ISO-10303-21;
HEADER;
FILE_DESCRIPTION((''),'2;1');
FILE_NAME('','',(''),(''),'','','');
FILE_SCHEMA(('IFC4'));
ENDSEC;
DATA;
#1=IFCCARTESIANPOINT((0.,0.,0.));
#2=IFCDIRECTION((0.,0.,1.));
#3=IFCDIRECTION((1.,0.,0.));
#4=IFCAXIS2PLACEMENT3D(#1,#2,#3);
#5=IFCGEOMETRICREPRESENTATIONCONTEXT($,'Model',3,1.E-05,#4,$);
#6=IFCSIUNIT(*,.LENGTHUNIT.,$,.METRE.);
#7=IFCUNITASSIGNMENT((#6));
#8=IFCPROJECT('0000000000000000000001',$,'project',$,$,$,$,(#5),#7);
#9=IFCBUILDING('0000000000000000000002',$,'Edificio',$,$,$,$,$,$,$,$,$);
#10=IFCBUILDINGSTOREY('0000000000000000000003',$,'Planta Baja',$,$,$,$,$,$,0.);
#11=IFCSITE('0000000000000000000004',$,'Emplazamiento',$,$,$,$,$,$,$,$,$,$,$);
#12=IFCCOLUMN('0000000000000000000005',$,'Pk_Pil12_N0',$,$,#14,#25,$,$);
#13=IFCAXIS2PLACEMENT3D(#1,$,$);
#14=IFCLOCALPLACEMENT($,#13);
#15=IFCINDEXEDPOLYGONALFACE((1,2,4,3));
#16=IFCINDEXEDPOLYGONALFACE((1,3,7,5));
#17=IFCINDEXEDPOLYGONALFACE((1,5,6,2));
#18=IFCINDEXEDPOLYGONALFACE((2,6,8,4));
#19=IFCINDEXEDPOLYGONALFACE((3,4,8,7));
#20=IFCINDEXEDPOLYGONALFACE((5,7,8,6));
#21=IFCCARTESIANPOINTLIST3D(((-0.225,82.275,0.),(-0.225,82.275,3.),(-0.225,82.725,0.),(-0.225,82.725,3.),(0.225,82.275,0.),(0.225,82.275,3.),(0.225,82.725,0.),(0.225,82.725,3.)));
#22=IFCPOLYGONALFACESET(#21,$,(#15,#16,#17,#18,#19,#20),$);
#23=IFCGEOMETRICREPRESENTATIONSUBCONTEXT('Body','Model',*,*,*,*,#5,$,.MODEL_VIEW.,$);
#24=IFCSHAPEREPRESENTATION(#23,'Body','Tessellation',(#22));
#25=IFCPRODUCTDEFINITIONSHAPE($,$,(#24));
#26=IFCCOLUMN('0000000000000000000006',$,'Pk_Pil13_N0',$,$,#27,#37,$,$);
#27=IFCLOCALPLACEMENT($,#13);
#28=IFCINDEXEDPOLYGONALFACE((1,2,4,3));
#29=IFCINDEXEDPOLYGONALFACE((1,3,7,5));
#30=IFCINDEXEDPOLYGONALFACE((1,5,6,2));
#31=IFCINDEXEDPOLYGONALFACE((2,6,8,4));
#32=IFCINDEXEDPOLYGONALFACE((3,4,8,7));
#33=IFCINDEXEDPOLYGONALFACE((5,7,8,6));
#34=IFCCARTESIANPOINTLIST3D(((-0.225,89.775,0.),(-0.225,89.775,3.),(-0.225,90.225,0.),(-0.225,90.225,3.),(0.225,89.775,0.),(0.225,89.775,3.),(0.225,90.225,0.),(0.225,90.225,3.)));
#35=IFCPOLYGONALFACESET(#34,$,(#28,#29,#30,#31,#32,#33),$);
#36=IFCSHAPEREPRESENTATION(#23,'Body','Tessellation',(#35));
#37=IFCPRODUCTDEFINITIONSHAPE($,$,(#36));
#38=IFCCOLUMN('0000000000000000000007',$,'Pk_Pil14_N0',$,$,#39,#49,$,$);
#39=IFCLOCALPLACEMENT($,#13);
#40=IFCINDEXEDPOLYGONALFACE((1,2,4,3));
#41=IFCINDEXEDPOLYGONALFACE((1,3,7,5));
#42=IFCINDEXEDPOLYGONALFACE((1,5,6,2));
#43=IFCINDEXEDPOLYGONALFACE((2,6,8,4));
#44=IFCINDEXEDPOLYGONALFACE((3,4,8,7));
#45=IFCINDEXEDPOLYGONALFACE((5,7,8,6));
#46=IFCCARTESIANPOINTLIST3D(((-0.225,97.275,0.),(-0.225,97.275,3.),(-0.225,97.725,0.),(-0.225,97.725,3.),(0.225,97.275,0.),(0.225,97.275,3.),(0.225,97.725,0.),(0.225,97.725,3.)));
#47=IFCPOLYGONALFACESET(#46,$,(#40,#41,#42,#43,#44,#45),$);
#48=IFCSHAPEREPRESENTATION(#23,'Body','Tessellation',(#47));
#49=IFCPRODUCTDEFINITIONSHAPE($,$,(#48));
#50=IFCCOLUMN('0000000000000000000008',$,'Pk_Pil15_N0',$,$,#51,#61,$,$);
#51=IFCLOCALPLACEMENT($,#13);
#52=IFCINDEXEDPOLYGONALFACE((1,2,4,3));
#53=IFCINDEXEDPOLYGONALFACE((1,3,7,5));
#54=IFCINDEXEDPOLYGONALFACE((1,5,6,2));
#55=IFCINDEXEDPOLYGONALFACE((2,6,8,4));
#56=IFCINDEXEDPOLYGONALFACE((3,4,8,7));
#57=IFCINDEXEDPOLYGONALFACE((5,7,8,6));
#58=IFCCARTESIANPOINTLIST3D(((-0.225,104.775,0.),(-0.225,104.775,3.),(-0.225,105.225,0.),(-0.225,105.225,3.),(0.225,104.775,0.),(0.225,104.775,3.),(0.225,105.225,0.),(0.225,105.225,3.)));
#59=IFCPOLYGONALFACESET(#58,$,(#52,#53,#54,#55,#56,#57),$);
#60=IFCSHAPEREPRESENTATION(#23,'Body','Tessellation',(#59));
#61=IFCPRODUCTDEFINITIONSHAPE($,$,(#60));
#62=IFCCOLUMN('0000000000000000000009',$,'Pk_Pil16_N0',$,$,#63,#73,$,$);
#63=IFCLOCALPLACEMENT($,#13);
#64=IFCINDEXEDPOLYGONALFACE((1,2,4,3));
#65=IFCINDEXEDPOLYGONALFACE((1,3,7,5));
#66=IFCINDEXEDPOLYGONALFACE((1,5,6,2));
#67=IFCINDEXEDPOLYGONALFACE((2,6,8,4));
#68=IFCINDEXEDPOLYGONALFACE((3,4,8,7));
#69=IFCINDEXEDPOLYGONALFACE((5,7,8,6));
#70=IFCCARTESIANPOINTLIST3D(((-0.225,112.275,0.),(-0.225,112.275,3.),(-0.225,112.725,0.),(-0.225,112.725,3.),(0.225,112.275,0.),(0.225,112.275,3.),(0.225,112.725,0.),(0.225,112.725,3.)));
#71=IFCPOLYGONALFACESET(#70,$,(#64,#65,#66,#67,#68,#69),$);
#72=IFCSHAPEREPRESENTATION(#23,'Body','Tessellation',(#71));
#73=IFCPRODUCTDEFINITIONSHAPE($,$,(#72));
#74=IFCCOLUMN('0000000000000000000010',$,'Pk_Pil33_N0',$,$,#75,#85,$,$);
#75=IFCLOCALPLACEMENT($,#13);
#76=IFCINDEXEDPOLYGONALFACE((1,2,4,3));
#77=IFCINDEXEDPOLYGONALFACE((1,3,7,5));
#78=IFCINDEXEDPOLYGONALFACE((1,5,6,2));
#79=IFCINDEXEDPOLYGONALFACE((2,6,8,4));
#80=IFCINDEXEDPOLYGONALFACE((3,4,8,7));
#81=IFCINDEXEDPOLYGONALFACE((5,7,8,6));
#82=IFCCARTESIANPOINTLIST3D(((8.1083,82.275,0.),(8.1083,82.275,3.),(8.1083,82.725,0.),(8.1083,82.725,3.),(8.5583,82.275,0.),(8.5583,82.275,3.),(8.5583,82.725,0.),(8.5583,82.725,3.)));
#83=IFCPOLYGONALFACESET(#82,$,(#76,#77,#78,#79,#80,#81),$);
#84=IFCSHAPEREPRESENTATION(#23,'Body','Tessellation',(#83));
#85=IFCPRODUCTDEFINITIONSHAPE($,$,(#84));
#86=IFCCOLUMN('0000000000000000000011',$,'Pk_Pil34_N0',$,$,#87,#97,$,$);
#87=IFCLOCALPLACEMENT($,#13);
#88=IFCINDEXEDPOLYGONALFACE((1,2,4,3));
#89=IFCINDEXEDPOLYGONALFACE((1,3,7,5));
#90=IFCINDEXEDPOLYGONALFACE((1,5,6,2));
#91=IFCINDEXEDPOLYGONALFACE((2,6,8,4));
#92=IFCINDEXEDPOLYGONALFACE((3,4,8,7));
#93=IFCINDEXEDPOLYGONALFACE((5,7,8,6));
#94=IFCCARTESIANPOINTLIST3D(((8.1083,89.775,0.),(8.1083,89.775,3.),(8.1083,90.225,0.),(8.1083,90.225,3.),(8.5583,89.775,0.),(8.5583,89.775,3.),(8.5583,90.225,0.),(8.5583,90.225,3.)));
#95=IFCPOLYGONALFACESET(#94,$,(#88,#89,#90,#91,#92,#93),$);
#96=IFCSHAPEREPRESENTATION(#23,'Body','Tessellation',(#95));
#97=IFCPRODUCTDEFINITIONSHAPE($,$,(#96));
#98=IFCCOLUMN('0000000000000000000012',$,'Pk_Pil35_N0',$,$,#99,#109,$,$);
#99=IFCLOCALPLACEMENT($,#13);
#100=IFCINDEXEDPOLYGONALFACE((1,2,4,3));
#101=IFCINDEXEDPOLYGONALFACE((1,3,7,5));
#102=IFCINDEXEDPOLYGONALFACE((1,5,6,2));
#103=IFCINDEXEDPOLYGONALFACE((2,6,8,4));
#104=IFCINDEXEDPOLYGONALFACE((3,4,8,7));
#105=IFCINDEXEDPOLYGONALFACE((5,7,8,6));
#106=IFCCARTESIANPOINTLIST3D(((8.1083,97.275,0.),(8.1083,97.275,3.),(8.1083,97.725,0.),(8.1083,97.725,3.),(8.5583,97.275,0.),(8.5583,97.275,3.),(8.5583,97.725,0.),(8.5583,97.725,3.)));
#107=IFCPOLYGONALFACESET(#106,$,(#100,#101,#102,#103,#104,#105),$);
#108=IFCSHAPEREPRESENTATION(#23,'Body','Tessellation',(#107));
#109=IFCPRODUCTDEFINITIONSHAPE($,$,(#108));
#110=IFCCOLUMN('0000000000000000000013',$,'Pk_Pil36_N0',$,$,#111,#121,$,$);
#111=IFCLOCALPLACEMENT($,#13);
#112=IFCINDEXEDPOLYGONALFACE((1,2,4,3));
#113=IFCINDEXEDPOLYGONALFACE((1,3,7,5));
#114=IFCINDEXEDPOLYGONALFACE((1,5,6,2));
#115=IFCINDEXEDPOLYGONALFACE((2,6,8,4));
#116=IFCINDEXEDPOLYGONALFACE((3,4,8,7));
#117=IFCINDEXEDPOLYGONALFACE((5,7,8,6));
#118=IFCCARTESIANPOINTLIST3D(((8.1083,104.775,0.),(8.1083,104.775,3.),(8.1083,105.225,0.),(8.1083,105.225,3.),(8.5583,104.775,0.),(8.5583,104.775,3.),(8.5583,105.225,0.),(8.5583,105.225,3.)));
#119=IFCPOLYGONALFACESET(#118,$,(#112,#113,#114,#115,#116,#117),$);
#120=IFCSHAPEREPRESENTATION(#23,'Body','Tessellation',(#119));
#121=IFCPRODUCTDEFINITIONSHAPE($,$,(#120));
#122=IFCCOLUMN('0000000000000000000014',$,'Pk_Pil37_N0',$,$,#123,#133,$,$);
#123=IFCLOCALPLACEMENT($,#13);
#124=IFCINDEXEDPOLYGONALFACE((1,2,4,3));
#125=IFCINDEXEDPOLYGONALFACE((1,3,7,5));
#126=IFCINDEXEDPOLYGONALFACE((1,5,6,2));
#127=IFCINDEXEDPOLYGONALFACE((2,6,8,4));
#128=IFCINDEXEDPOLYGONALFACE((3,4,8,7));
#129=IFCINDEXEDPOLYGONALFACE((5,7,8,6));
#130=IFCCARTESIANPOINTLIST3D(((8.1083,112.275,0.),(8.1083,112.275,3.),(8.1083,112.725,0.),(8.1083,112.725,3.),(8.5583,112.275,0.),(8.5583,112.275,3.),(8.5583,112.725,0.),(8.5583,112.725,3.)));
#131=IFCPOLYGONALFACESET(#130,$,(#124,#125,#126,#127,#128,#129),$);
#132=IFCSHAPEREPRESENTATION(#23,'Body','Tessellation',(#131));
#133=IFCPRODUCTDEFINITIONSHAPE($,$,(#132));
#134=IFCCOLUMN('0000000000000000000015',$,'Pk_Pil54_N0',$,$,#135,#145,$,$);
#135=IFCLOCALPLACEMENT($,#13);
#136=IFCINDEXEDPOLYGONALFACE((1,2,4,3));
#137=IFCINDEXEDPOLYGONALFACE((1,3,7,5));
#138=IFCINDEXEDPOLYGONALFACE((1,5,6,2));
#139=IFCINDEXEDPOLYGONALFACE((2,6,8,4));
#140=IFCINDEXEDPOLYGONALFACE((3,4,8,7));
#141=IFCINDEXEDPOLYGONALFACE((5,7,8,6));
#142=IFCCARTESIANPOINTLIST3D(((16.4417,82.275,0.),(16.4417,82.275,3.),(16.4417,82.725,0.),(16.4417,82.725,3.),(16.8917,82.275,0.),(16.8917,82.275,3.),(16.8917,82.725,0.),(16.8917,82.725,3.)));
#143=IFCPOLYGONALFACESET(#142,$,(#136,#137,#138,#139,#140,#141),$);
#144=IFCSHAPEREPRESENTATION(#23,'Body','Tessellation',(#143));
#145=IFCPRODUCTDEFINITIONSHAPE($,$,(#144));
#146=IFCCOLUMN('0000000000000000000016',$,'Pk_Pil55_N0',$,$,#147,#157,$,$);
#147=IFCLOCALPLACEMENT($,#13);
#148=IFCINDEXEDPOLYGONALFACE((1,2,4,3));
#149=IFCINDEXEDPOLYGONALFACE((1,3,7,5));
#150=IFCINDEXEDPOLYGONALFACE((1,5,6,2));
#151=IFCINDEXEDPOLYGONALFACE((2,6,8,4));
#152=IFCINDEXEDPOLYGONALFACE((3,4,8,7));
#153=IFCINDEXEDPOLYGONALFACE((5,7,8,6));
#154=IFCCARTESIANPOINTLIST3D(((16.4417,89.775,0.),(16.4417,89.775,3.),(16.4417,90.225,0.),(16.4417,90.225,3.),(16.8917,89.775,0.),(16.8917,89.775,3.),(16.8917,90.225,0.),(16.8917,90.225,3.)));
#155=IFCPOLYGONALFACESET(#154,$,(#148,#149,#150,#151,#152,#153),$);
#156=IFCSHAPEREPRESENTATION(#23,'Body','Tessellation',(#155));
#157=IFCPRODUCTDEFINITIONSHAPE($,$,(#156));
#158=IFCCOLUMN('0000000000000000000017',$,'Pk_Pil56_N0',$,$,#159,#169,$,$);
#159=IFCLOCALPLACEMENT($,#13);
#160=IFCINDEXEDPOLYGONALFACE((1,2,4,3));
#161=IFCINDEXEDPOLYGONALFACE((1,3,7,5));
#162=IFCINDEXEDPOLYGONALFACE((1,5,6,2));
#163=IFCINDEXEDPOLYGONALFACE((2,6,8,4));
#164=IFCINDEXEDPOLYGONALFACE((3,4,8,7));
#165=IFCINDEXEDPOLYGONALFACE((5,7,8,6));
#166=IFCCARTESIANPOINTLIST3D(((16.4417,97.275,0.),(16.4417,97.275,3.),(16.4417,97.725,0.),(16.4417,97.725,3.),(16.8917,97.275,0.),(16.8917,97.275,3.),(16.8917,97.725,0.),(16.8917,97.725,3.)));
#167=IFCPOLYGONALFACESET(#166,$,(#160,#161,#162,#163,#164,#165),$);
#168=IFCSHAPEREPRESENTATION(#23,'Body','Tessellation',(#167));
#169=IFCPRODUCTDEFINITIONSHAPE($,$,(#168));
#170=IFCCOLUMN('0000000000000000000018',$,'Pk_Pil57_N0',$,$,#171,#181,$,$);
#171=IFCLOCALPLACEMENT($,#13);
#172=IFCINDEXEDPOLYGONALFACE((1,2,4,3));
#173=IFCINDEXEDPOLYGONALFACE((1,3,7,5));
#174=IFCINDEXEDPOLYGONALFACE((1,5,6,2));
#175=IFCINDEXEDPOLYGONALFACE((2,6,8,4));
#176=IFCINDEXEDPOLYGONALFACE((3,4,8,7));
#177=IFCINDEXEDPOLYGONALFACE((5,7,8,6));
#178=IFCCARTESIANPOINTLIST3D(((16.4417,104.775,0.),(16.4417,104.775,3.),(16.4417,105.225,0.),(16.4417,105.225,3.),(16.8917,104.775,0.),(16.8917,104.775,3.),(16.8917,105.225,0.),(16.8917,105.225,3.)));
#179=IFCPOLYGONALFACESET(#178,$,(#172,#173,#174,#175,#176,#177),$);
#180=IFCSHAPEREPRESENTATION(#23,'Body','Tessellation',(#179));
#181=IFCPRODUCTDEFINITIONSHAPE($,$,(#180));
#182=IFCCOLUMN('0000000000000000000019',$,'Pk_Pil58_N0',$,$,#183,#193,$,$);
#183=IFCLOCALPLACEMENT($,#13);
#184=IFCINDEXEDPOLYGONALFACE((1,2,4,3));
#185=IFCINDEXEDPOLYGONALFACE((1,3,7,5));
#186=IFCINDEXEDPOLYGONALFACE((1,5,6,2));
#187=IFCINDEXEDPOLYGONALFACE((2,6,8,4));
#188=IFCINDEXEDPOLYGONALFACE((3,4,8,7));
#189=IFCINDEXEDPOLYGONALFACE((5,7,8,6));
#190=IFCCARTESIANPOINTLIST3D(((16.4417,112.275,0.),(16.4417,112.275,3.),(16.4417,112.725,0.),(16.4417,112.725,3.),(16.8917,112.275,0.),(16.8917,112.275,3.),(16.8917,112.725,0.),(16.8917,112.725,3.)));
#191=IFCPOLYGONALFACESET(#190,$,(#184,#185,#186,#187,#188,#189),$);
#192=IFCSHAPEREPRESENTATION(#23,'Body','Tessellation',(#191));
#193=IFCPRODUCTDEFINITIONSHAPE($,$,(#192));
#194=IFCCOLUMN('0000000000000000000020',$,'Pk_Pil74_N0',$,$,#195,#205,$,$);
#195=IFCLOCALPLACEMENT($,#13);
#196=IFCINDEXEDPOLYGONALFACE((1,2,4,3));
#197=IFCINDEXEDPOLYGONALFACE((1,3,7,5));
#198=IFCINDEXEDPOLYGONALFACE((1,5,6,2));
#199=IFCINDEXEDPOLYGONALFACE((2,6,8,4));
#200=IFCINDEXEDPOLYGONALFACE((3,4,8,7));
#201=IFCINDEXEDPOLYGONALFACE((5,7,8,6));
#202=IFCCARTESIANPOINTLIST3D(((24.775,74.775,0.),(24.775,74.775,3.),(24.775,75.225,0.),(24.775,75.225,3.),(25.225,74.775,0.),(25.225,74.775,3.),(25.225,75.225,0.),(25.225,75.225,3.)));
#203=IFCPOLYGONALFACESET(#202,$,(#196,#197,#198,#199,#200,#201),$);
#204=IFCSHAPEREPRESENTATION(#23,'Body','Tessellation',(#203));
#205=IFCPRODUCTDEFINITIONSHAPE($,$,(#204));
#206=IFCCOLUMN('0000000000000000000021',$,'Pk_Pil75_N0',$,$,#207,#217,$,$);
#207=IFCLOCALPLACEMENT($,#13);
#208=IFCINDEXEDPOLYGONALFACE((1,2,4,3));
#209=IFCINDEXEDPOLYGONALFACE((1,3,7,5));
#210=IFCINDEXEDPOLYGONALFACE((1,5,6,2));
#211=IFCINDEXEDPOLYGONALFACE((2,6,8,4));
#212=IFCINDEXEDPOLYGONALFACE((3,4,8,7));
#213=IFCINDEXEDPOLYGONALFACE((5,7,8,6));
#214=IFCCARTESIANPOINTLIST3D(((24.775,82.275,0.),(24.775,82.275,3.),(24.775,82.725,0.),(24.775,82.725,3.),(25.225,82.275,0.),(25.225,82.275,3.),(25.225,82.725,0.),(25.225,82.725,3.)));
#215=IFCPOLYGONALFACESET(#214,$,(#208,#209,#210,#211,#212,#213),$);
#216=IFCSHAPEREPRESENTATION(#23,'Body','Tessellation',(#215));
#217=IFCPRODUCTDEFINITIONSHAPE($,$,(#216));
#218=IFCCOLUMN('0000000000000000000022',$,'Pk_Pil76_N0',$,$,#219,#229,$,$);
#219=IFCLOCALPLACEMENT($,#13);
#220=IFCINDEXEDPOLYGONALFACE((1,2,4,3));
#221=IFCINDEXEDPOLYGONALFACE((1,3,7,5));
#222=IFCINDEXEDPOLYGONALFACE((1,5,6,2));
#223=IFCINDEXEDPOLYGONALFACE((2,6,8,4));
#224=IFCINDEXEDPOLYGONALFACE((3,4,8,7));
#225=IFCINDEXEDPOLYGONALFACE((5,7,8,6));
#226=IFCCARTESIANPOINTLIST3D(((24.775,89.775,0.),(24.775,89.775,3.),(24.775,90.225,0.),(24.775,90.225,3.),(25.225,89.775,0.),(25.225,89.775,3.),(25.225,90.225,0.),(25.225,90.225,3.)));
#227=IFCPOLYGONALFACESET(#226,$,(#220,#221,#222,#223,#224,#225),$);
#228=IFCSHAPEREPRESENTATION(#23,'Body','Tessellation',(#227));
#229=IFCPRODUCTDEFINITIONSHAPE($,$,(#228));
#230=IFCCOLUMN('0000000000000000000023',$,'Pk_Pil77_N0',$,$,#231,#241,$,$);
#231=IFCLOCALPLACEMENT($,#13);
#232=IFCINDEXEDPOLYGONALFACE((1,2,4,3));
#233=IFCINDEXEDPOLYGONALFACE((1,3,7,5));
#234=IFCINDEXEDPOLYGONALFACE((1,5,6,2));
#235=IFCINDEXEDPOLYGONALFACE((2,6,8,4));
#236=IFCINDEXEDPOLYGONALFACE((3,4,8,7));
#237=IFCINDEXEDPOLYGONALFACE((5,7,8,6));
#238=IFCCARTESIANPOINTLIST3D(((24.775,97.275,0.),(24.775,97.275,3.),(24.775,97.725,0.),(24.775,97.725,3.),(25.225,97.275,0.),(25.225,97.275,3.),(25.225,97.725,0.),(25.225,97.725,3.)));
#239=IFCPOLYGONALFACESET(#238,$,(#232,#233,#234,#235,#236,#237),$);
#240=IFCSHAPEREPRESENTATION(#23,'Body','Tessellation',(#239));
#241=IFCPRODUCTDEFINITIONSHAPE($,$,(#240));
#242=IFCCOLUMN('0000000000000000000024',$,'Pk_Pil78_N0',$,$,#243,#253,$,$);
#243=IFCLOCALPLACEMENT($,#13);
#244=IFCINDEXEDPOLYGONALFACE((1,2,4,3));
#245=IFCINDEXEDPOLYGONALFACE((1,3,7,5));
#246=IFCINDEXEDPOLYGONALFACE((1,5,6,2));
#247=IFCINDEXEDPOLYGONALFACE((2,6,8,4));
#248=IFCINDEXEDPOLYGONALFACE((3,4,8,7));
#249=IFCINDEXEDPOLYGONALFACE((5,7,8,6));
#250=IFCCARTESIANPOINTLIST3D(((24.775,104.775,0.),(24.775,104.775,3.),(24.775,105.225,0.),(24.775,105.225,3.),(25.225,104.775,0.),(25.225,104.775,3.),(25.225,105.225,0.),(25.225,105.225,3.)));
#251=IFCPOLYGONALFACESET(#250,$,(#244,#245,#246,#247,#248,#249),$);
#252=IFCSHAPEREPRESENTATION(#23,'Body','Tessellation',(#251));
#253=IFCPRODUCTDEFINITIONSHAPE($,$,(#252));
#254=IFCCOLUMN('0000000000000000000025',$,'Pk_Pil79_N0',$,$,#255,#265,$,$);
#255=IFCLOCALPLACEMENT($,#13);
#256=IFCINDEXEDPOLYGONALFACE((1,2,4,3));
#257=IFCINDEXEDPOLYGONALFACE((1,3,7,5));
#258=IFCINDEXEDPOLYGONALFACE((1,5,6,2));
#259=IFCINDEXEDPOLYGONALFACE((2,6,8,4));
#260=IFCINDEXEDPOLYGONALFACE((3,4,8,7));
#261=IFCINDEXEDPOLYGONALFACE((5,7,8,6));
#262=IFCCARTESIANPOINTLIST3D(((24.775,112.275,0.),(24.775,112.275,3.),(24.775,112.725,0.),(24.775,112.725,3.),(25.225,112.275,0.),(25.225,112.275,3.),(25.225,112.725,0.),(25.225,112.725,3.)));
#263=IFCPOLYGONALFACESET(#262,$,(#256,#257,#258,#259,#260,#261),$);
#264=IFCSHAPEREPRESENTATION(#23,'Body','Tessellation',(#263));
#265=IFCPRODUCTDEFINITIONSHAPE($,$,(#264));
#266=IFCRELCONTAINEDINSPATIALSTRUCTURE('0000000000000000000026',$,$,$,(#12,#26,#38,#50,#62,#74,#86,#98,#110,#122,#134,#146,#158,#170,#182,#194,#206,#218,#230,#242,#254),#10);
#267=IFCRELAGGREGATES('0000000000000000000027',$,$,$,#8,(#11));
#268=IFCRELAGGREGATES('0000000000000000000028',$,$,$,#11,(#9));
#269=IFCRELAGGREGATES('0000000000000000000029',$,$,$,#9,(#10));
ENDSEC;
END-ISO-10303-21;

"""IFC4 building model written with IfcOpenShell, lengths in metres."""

from ifc_helpers import new_model, si_unit, frame, origin_with_axes, origin_2d, place, context, subcontext, project, spatial, rectangle, extrude, element, save


model = new_model("IFC4")

# Units and contexts
model_context = context("Model", 3, precision=1e-05, world=origin_with_axes())
body_context = subcontext(model_context, "Body", "Model", "MODEL_VIEW")
ifc_project = project(units=[si_unit("LENGTHUNIT", "METRE")], contexts=[model_context])

# Site, building, storey
site = spatial("IfcSite", under=ifc_project, Name="Emplazamiento")
building = spatial("IfcBuilding", under=site, Name="Edificio")
storey = spatial("IfcBuildingStorey", under=building, Name="Planta Baja", Elevation=0.0)

# Columns
for number, where, z_axis, x_axis, name in (
    (1, (0.0, 82.5, 0.0), (0.0, 0.0, 1.0), (1.0, 0.0, 0.0), "Pk_Pil12_N0"),
    (2, (0.0, 90.0, 0.0), (0.0, 0.0, 1.0), (1.0, 0.0, 0.0), "Pk_Pil13_N0"),
    (3, (0.0, 97.5, 0.0), (0.0, 0.0, 1.0), (1.0, 0.0, 0.0), "Pk_Pil14_N0"),
    (4, (0.0, 105.0, 0.0), (0.0, 0.0, 1.0), (1.0, 0.0, 0.0), "Pk_Pil15_N0"),
    (5, (0.0, 112.5, 0.0), (0.0, 0.0, 1.0), (1.0, 0.0, 0.0), "Pk_Pil16_N0"),
    (6, (8.3333, 82.5, 0.0), (0.0, 0.0, 1.0), (1.0, 0.0, 0.0), "Pk_Pil33_N0"),
    (7, (8.3333, 90.0, 0.0), (0.0, 0.0, 1.0), (1.0, 0.0, 0.0), "Pk_Pil34_N0"),
    (8, (8.3333, 97.5, 0.0), (0.0, 0.0, 1.0), (1.0, 0.0, 0.0), "Pk_Pil35_N0"),
    (9, (8.3333, 105.0, 0.0), (0.0, 0.0, 1.0), (1.0, 0.0, 0.0), "Pk_Pil36_N0"),
    (10, (8.3333, 112.5, 0.0), (0.0, 0.0, 1.0), (1.0, 0.0, 0.0), "Pk_Pil37_N0"),
    (11, (16.6667, 82.5, 0.0), (0.0, 0.0, 1.0), (1.0, 0.0, 0.0), "Pk_Pil54_N0"),
    (12, (16.6667, 90.0, 0.0), (0.0, 0.0, 1.0), (1.0, 0.0, 0.0), "Pk_Pil55_N0"),
    (13, (16.6667, 97.5, 0.0), (0.0, 0.0, 1.0), (1.0, 0.0, 0.0), "Pk_Pil56_N0"),
    (14, (16.6667, 105.0, 0.0), (0.0, 0.0, 1.0), (1.0, 0.0, 0.0), "Pk_Pil57_N0"),
    (15, (16.6667, 112.5, 0.0), (0.0, 0.0, 1.0), (1.0, 0.0, 0.0), "Pk_Pil58_N0"),
    (16, (25.0, 75.0, 0.0), (0.0, 0.0, 1.0), (1.0, 0.0, 0.0), "Pk_Pil74_N0"),
    (17, (25.0, 82.5, 0.0), (0.0, 0.0, 1.0), (1.0, 0.0, 0.0), "Pk_Pil75_N0"),
    (18, (25.0, 90.0, 0.0), (0.0, 0.0, 1.0), (1.0, 0.0, 0.0), "Pk_Pil76_N0"),
    (19, (25.0, 97.5, 0.0), (0.0, 0.0, 1.0), (1.0, 0.0, 0.0), "Pk_Pil77_N0"),
    (20, (25.0, 105.0, 0.0), (0.0, 0.0, 1.0), (1.0, 0.0, 0.0), "Pk_Pil78_N0"),
    (21, (25.0, 112.5, 0.0), (0.0, 0.0, 1.0), (1.0, 0.0, 0.0), "Pk_Pil79_N0"),
):
    element("IfcColumn", number, at=place(None, frame(where, z_axis=z_axis, x_axis=x_axis)), inside=storey, Name=name, context=body_context, shape_type="SweptSolid", body=[
        extrude(rectangle(XDim=0.45, YDim=0.45, at=origin_2d()), origin_with_axes(), (0.0, 0.0, 1.0), 3.0),
    ])

save(model, "model.ifc")
